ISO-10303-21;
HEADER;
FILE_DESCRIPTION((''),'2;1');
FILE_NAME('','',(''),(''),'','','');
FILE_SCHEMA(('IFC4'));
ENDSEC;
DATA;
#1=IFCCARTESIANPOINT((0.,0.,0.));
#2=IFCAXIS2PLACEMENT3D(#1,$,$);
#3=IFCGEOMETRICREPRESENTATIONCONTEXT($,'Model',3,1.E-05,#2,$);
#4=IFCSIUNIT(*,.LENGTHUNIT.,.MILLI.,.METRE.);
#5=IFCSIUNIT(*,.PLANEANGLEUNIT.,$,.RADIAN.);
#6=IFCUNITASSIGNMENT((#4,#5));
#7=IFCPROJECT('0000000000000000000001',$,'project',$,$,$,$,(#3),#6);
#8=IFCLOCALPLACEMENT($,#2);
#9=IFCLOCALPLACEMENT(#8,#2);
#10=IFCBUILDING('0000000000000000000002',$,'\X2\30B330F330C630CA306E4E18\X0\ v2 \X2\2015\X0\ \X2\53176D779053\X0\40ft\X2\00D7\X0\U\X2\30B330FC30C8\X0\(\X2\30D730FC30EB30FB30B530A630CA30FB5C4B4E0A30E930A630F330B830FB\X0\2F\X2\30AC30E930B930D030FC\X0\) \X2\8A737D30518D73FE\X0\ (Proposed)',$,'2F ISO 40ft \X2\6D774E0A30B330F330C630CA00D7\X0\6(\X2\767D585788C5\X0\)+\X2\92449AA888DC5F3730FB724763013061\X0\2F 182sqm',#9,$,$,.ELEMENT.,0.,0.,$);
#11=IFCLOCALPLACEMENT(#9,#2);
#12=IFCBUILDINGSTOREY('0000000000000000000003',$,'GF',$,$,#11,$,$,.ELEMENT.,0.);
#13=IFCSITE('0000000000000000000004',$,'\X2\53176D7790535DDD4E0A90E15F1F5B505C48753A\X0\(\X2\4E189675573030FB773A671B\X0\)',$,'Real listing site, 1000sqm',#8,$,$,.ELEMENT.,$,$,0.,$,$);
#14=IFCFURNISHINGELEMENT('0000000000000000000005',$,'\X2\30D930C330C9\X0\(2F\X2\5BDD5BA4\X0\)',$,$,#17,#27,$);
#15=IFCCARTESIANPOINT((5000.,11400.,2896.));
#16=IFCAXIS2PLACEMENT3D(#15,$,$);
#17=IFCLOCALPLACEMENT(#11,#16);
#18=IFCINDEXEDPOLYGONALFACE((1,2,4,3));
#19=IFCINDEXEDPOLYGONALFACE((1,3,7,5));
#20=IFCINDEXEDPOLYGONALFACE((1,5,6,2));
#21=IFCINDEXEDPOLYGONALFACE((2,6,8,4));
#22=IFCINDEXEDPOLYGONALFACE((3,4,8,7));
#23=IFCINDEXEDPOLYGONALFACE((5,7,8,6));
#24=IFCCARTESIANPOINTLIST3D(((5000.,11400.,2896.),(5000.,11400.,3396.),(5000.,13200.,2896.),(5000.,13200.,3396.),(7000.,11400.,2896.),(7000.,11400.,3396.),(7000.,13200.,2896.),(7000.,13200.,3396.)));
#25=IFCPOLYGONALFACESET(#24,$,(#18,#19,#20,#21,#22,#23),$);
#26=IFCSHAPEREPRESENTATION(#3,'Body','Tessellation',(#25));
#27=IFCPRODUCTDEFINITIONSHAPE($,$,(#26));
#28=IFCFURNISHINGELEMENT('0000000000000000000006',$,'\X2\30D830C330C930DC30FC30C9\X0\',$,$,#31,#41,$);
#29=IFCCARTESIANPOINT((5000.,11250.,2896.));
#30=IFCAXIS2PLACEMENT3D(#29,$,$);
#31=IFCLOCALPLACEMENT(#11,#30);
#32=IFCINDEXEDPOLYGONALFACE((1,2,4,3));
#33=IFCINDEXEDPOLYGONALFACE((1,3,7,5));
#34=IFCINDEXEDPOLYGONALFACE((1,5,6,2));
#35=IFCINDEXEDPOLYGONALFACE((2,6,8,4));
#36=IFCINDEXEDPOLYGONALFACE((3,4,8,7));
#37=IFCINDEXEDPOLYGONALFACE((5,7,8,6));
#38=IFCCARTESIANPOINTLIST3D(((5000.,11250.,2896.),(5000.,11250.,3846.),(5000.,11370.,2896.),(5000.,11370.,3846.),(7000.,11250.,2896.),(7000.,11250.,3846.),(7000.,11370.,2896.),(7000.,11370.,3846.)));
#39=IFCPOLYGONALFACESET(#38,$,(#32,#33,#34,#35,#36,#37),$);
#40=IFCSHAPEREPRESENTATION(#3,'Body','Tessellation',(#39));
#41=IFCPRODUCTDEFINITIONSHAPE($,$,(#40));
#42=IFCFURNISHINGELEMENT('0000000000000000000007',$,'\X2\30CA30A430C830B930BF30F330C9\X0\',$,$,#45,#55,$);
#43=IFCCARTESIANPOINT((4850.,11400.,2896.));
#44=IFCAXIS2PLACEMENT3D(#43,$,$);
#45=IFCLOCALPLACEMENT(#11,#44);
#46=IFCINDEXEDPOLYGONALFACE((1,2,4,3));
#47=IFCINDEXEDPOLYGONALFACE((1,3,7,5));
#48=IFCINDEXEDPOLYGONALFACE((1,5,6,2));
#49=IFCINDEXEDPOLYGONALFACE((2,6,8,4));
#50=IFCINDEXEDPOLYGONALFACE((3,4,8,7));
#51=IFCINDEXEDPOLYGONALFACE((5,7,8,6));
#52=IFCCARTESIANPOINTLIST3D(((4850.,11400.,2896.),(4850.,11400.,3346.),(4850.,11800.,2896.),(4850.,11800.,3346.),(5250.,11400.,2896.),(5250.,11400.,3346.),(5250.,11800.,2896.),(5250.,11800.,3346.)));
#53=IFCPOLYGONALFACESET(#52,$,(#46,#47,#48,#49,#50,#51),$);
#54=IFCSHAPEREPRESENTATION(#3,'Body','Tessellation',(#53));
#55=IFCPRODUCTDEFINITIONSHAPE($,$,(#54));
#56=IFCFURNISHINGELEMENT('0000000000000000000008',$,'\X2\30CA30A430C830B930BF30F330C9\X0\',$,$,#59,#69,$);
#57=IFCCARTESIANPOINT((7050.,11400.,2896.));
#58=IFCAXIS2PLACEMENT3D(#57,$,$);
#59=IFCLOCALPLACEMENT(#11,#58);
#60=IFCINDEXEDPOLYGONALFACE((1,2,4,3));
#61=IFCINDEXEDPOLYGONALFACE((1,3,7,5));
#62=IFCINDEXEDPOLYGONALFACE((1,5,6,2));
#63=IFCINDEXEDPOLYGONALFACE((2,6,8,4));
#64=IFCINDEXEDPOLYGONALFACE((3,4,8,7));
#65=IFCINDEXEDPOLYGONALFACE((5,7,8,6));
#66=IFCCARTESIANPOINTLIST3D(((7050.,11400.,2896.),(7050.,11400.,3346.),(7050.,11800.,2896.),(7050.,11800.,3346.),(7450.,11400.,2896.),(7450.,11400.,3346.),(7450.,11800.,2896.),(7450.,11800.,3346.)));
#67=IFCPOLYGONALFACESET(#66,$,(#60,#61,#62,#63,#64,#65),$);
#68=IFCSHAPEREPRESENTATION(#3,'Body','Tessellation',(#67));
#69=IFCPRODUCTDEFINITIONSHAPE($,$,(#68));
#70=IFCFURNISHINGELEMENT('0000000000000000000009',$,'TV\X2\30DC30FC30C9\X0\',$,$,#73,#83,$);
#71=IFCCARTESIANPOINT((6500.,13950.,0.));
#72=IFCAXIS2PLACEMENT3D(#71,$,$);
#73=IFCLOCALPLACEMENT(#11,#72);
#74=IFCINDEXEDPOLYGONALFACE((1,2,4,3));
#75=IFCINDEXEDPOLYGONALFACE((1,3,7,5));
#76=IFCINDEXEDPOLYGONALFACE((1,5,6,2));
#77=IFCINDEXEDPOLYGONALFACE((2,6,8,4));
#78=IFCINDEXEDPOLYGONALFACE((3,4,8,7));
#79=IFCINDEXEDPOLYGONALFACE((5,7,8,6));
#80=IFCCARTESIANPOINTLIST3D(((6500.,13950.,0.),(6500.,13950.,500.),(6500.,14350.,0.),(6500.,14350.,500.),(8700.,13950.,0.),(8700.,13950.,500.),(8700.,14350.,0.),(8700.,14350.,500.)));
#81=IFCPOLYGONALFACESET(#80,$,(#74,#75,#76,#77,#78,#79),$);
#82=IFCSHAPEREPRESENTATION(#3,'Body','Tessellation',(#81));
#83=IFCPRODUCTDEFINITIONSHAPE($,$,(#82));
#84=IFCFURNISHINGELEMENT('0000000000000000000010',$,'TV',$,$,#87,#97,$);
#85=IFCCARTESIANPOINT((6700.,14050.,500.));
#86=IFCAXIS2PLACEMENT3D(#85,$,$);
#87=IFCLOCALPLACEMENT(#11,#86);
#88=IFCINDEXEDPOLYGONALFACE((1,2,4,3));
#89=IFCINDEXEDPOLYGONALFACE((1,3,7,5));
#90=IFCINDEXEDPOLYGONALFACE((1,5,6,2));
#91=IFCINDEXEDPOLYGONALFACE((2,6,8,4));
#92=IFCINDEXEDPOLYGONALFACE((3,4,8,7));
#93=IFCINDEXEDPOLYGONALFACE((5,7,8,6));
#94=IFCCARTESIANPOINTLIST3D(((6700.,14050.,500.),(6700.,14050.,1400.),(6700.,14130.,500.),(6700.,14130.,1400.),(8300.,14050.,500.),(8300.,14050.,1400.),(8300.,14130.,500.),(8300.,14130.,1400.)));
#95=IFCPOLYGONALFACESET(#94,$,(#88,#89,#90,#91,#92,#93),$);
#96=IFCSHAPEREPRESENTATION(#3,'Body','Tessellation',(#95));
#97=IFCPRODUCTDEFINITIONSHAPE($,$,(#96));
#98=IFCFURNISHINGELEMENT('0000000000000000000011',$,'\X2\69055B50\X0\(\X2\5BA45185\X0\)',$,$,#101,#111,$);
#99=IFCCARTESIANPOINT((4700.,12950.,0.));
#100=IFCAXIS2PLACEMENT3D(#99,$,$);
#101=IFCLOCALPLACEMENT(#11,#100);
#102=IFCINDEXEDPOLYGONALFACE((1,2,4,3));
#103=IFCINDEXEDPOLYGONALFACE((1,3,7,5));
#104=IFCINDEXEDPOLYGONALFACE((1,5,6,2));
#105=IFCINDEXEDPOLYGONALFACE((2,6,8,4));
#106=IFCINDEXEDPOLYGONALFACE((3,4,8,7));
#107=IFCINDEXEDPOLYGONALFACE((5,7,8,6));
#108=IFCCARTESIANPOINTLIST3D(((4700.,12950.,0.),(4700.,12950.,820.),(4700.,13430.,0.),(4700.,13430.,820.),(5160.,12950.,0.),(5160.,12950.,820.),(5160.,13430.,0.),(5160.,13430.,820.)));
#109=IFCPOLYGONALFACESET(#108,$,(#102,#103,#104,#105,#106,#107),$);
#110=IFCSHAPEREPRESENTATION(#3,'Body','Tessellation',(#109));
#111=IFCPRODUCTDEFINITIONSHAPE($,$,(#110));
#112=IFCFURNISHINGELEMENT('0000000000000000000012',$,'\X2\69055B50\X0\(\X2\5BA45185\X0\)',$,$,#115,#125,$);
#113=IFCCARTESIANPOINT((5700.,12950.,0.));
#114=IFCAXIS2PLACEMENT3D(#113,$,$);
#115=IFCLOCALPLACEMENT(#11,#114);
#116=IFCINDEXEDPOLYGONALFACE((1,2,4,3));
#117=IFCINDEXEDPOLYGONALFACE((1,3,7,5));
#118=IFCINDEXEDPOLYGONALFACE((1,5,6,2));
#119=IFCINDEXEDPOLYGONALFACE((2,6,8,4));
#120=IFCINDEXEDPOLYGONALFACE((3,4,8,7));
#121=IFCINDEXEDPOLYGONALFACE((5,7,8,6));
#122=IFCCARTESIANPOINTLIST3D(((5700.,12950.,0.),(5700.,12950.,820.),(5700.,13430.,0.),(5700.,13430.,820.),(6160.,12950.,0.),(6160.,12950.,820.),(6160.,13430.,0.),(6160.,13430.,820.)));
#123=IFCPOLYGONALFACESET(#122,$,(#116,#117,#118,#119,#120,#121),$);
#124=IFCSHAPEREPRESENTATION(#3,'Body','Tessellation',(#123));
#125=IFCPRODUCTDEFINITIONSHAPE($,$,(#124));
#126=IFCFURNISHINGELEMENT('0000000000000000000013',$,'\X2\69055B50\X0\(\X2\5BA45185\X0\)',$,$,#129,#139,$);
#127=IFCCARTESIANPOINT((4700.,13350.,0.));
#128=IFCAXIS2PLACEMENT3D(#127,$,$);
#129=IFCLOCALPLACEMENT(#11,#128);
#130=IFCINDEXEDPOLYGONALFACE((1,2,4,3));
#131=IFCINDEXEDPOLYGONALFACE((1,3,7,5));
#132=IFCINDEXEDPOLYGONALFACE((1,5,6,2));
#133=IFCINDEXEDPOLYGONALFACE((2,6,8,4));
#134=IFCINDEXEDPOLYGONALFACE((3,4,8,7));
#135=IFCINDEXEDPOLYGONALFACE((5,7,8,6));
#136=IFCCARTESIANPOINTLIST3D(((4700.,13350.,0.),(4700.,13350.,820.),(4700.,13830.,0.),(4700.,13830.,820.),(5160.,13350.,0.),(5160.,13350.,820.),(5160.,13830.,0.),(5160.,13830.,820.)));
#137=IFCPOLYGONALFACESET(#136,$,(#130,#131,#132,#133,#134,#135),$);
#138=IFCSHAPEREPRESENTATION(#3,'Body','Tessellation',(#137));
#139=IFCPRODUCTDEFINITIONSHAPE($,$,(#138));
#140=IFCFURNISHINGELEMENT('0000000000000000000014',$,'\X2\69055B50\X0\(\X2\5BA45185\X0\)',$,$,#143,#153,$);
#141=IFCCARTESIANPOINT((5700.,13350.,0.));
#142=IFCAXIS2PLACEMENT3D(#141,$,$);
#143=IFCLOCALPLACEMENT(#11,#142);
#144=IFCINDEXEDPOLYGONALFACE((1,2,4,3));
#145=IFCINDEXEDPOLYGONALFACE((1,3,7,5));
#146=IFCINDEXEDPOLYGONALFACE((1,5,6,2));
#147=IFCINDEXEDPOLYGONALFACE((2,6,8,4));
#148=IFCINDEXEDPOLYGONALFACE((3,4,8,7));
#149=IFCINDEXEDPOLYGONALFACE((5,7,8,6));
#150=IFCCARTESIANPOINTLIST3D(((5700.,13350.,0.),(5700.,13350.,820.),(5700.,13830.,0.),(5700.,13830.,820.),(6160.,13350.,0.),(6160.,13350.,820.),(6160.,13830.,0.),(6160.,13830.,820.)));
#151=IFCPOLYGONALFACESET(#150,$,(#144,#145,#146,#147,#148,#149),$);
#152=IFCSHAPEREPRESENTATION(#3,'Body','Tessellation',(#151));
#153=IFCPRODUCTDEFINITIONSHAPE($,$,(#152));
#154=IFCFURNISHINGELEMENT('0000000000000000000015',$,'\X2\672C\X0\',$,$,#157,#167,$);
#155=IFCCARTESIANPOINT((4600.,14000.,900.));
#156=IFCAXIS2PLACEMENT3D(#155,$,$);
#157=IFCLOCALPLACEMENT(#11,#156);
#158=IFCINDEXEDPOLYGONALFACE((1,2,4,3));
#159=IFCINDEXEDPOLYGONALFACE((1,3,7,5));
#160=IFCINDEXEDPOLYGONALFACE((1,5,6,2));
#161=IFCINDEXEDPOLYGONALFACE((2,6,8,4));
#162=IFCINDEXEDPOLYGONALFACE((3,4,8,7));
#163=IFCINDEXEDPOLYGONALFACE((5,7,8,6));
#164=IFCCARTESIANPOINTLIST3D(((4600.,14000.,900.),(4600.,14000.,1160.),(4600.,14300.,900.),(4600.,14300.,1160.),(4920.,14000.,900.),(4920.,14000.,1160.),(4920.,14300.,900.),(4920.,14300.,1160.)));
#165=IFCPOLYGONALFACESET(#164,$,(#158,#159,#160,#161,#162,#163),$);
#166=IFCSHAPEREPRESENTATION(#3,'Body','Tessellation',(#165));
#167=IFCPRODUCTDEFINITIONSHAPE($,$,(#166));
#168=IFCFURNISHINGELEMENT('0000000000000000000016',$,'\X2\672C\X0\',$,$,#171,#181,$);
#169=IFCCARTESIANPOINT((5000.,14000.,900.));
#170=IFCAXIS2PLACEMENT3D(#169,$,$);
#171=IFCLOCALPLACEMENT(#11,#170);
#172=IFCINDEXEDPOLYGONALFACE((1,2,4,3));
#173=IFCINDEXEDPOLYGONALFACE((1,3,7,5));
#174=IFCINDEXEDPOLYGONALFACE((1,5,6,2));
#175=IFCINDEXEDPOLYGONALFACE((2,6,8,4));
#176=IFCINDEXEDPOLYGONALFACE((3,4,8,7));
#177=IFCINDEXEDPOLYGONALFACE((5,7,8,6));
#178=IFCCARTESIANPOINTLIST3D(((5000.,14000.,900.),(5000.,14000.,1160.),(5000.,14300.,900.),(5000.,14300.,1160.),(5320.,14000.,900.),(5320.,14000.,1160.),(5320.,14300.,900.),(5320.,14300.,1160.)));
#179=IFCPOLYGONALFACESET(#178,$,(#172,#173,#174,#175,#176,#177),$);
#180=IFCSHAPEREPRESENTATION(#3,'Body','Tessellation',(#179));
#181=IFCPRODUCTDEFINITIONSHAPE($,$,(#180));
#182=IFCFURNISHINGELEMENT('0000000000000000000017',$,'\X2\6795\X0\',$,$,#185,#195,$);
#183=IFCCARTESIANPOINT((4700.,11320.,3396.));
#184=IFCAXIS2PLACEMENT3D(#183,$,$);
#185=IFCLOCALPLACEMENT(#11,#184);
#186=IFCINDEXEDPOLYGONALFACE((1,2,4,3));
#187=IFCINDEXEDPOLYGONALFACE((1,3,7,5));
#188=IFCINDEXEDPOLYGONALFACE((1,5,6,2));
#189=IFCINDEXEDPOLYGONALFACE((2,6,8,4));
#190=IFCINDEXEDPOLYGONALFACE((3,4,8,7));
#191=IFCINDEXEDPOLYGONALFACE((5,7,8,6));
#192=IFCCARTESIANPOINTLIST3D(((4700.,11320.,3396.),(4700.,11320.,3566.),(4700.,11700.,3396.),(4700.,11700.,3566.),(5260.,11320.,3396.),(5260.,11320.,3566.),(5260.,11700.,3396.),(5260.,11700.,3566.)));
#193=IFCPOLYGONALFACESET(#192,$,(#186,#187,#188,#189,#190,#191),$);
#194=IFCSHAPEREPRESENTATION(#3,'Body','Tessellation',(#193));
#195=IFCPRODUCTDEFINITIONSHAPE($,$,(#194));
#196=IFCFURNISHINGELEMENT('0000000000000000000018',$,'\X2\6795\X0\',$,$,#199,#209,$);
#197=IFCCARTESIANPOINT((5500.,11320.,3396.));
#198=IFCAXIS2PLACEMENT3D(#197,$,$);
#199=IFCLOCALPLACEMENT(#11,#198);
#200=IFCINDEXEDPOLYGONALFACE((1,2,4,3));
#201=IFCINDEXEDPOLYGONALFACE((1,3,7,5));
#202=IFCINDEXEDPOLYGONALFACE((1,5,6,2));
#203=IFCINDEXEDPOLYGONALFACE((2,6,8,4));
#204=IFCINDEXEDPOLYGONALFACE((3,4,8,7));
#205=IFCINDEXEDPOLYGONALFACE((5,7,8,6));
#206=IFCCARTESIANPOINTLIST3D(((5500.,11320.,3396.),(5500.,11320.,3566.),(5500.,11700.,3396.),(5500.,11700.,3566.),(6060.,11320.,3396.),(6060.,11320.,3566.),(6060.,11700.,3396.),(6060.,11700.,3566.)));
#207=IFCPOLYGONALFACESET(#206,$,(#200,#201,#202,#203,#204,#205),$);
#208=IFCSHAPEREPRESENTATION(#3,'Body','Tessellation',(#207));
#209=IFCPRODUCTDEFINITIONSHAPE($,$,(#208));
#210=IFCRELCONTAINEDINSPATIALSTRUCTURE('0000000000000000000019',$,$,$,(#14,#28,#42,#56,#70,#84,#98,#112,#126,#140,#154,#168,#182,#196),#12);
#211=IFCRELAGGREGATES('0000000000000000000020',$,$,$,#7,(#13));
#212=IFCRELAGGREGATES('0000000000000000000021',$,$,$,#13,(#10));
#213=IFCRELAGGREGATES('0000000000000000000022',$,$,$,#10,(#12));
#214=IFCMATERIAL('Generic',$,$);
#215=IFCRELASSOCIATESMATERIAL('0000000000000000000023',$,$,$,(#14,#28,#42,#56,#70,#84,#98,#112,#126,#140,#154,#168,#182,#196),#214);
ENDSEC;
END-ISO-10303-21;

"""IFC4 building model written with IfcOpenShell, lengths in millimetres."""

from ifc_helpers import new_model, si_unit, frame, frame_2d, origin, place, context, project, spatial, rectangle, extrude, material, element, save


model = new_model("IFC4")

# Units and contexts
model_context = context("Model", 3, precision=1e-05, world=origin())
ifc_project = project(units=[si_unit("LENGTHUNIT", "METRE", prefix="MILLI"), si_unit("PLANEANGLEUNIT", "RADIAN")], contexts=[model_context])

# Site, building, storey
site_placement = place(None, origin())
site = spatial("IfcSite", under=ifc_project, at=site_placement, Name="北海道川上郡弟子屈町(丘陵地・眺望)", ObjectType="Real listing site, 1000sqm", CompositionType="ELEMENT", RefElevation=0.0)
building_placement = place(site_placement, origin())
building = spatial("IfcBuilding", under=site, at=building_placement, Name="コンテナの丘 v2 ― 北海道40ft×Uコート(プール・サウナ・屋上ラウンジ・2Fガラスバー) 詳細再現 (Proposed)", ObjectType="2F ISO 40ft 海上コンテナ×6(白塗装)+鉄骨補強・片持ち2F 182sqm", CompositionType="ELEMENT", ElevationOfRefHeight=0.0, ElevationOfTerrain=0.0)
storey_placement = place(building_placement, origin())
storey = spatial("IfcBuildingStorey", under=building, at=storey_placement, Name="GF", CompositionType="ELEMENT", Elevation=0.0)

# Shared definitions
ifc_material = material(Name="Generic")

# Furnishing elements
furnishing_1_placement = place(storey_placement, frame((5000.0, 11400.0, 2896.0)))
element("IfcFurnishingElement", 1, at=furnishing_1_placement, inside=storey, material=ifc_material, Name="ベッド(2F寝室)", context=model_context, shape_type="SweptSolid", body=[
    extrude(rectangle(XDim=2000.0, YDim=1800.0, at=frame_2d((1000.0, 900.0))), frame((5000.0, 11400.0, 2896.0)), (0.0, 0.0, 1.0), 500.0),
])
furnishing_2_placement = place(storey_placement, frame((5000.0, 11250.0, 2896.0)))
element("IfcFurnishingElement", 2, at=furnishing_2_placement, inside=storey, material=ifc_material, Name="ヘッドボード", context=model_context, shape_type="SweptSolid", body=[
    extrude(rectangle(XDim=2000.0, YDim=120.0, at=frame_2d((1000.0, 60.0))), frame((5000.0, 11250.0, 2896.0)), (0.0, 0.0, 1.0), 950.0),
])
furnishing_3_placement = place(storey_placement, frame((4850.0, 11400.0, 2896.0)))
element("IfcFurnishingElement", 3, at=furnishing_3_placement, inside=storey, material=ifc_material, Name="ナイトスタンド", context=model_context, shape_type="SweptSolid", body=[
    extrude(rectangle(XDim=400.0, YDim=400.0, at=frame_2d((200.0, 200.0))), frame((4850.0, 11400.0, 2896.0)), (0.0, 0.0, 1.0), 450.0),
])
furnishing_4_placement = place(storey_placement, frame((7050.0, 11400.0, 2896.0)))
element("IfcFurnishingElement", 4, at=furnishing_4_placement, inside=storey, material=ifc_material, Name="ナイトスタンド", context=model_context, shape_type="SweptSolid", body=[
    extrude(rectangle(XDim=400.0, YDim=400.0, at=frame_2d((200.0, 200.0))), frame((7050.0, 11400.0, 2896.0)), (0.0, 0.0, 1.0), 450.0),
])
furnishing_5_placement = place(storey_placement, frame((6500.0, 13950.0, 0.0)))
element("IfcFurnishingElement", 5, at=furnishing_5_placement, inside=storey, material=ifc_material, Name="TVボード", context=model_context, shape_type="SweptSolid", body=[
    extrude(rectangle(XDim=2200.0, YDim=400.0, at=frame_2d((1100.0, 200.0))), frame((6500.0, 13950.0, 0.0)), (0.0, 0.0, 1.0), 500.0),
])
furnishing_6_placement = place(storey_placement, frame((6700.0, 14050.0, 500.0)))
element("IfcFurnishingElement", 6, at=furnishing_6_placement, inside=storey, material=ifc_material, Name="TV", context=model_context, shape_type="SweptSolid", body=[
    extrude(rectangle(XDim=1600.0, YDim=80.0, at=frame_2d((800.0, 40.0))), frame((6700.0, 14050.0, 500.0)), (0.0, 0.0, 1.0), 900.0),
])
furnishing_7_placement = place(storey_placement, frame((4700.0, 12950.0, 0.0)))
element("IfcFurnishingElement", 7, at=furnishing_7_placement, inside=storey, material=ifc_material, Name="椅子(室内)", context=model_context, shape_type="SweptSolid", body=[
    extrude(rectangle(XDim=460.0, YDim=480.0, at=frame_2d((230.0, 240.0))), frame((4700.0, 12950.0, 0.0)), (0.0, 0.0, 1.0), 820.0),
])
furnishing_8_placement = place(storey_placement, frame((5700.0, 12950.0, 0.0)))
element("IfcFurnishingElement", 8, at=furnishing_8_placement, inside=storey, material=ifc_material, Name="椅子(室内)", context=model_context, shape_type="SweptSolid", body=[
    extrude(rectangle(XDim=460.0, YDim=480.0, at=frame_2d((230.0, 240.0))), frame((5700.0, 12950.0, 0.0)), (0.0, 0.0, 1.0), 820.0),
])
furnishing_9_placement = place(storey_placement, frame((4700.0, 13350.0, 0.0)))
element("IfcFurnishingElement", 9, at=furnishing_9_placement, inside=storey, material=ifc_material, Name="椅子(室内)", context=model_context, shape_type="SweptSolid", body=[
    extrude(rectangle(XDim=460.0, YDim=480.0, at=frame_2d((230.0, 240.0))), frame((4700.0, 13350.0, 0.0)), (0.0, 0.0, 1.0), 820.0),
])
furnishing_10_placement = place(storey_placement, frame((5700.0, 13350.0, 0.0)))
element("IfcFurnishingElement", 10, at=furnishing_10_placement, inside=storey, material=ifc_material, Name="椅子(室内)", context=model_context, shape_type="SweptSolid", body=[
    extrude(rectangle(XDim=460.0, YDim=480.0, at=frame_2d((230.0, 240.0))), frame((5700.0, 13350.0, 0.0)), (0.0, 0.0, 1.0), 820.0),
])
furnishing_11_placement = place(storey_placement, frame((4600.0, 14000.0, 900.0)))
element("IfcFurnishingElement", 11, at=furnishing_11_placement, inside=storey, material=ifc_material, Name="本", context=model_context, shape_type="SweptSolid", body=[
    extrude(rectangle(XDim=320.0, YDim=300.0, at=frame_2d((160.0, 150.0))), frame((4600.0, 14000.0, 900.0)), (0.0, 0.0, 1.0), 260.0),
])
furnishing_12_placement = place(storey_placement, frame((5000.0, 14000.0, 900.0)))
element("IfcFurnishingElement", 12, at=furnishing_12_placement, inside=storey, material=ifc_material, Name="本", context=model_context, shape_type="SweptSolid", body=[
    extrude(rectangle(XDim=320.0, YDim=300.0, at=frame_2d((160.0, 150.0))), frame((5000.0, 14000.0, 900.0)), (0.0, 0.0, 1.0), 260.0),
])
furnishing_13_placement = place(storey_placement, frame((4700.0, 11320.0, 3396.0)))
element("IfcFurnishingElement", 13, at=furnishing_13_placement, inside=storey, material=ifc_material, Name="枕", context=model_context, shape_type="SweptSolid", body=[
    extrude(rectangle(XDim=560.0, YDim=380.0, at=frame_2d((280.0, 190.0))), frame((4700.0, 11320.0, 3396.0)), (0.0, 0.0, 1.0), 170.0),
])
furnishing_14_placement = place(storey_placement, frame((5500.0, 11320.0, 3396.0)))
element("IfcFurnishingElement", 14, at=furnishing_14_placement, inside=storey, material=ifc_material, Name="枕", context=model_context, shape_type="SweptSolid", body=[
    extrude(rectangle(XDim=560.0, YDim=380.0, at=frame_2d((280.0, 190.0))), frame((5500.0, 11320.0, 3396.0)), (0.0, 0.0, 1.0), 170.0),
])

save(model, "model.ifc")
